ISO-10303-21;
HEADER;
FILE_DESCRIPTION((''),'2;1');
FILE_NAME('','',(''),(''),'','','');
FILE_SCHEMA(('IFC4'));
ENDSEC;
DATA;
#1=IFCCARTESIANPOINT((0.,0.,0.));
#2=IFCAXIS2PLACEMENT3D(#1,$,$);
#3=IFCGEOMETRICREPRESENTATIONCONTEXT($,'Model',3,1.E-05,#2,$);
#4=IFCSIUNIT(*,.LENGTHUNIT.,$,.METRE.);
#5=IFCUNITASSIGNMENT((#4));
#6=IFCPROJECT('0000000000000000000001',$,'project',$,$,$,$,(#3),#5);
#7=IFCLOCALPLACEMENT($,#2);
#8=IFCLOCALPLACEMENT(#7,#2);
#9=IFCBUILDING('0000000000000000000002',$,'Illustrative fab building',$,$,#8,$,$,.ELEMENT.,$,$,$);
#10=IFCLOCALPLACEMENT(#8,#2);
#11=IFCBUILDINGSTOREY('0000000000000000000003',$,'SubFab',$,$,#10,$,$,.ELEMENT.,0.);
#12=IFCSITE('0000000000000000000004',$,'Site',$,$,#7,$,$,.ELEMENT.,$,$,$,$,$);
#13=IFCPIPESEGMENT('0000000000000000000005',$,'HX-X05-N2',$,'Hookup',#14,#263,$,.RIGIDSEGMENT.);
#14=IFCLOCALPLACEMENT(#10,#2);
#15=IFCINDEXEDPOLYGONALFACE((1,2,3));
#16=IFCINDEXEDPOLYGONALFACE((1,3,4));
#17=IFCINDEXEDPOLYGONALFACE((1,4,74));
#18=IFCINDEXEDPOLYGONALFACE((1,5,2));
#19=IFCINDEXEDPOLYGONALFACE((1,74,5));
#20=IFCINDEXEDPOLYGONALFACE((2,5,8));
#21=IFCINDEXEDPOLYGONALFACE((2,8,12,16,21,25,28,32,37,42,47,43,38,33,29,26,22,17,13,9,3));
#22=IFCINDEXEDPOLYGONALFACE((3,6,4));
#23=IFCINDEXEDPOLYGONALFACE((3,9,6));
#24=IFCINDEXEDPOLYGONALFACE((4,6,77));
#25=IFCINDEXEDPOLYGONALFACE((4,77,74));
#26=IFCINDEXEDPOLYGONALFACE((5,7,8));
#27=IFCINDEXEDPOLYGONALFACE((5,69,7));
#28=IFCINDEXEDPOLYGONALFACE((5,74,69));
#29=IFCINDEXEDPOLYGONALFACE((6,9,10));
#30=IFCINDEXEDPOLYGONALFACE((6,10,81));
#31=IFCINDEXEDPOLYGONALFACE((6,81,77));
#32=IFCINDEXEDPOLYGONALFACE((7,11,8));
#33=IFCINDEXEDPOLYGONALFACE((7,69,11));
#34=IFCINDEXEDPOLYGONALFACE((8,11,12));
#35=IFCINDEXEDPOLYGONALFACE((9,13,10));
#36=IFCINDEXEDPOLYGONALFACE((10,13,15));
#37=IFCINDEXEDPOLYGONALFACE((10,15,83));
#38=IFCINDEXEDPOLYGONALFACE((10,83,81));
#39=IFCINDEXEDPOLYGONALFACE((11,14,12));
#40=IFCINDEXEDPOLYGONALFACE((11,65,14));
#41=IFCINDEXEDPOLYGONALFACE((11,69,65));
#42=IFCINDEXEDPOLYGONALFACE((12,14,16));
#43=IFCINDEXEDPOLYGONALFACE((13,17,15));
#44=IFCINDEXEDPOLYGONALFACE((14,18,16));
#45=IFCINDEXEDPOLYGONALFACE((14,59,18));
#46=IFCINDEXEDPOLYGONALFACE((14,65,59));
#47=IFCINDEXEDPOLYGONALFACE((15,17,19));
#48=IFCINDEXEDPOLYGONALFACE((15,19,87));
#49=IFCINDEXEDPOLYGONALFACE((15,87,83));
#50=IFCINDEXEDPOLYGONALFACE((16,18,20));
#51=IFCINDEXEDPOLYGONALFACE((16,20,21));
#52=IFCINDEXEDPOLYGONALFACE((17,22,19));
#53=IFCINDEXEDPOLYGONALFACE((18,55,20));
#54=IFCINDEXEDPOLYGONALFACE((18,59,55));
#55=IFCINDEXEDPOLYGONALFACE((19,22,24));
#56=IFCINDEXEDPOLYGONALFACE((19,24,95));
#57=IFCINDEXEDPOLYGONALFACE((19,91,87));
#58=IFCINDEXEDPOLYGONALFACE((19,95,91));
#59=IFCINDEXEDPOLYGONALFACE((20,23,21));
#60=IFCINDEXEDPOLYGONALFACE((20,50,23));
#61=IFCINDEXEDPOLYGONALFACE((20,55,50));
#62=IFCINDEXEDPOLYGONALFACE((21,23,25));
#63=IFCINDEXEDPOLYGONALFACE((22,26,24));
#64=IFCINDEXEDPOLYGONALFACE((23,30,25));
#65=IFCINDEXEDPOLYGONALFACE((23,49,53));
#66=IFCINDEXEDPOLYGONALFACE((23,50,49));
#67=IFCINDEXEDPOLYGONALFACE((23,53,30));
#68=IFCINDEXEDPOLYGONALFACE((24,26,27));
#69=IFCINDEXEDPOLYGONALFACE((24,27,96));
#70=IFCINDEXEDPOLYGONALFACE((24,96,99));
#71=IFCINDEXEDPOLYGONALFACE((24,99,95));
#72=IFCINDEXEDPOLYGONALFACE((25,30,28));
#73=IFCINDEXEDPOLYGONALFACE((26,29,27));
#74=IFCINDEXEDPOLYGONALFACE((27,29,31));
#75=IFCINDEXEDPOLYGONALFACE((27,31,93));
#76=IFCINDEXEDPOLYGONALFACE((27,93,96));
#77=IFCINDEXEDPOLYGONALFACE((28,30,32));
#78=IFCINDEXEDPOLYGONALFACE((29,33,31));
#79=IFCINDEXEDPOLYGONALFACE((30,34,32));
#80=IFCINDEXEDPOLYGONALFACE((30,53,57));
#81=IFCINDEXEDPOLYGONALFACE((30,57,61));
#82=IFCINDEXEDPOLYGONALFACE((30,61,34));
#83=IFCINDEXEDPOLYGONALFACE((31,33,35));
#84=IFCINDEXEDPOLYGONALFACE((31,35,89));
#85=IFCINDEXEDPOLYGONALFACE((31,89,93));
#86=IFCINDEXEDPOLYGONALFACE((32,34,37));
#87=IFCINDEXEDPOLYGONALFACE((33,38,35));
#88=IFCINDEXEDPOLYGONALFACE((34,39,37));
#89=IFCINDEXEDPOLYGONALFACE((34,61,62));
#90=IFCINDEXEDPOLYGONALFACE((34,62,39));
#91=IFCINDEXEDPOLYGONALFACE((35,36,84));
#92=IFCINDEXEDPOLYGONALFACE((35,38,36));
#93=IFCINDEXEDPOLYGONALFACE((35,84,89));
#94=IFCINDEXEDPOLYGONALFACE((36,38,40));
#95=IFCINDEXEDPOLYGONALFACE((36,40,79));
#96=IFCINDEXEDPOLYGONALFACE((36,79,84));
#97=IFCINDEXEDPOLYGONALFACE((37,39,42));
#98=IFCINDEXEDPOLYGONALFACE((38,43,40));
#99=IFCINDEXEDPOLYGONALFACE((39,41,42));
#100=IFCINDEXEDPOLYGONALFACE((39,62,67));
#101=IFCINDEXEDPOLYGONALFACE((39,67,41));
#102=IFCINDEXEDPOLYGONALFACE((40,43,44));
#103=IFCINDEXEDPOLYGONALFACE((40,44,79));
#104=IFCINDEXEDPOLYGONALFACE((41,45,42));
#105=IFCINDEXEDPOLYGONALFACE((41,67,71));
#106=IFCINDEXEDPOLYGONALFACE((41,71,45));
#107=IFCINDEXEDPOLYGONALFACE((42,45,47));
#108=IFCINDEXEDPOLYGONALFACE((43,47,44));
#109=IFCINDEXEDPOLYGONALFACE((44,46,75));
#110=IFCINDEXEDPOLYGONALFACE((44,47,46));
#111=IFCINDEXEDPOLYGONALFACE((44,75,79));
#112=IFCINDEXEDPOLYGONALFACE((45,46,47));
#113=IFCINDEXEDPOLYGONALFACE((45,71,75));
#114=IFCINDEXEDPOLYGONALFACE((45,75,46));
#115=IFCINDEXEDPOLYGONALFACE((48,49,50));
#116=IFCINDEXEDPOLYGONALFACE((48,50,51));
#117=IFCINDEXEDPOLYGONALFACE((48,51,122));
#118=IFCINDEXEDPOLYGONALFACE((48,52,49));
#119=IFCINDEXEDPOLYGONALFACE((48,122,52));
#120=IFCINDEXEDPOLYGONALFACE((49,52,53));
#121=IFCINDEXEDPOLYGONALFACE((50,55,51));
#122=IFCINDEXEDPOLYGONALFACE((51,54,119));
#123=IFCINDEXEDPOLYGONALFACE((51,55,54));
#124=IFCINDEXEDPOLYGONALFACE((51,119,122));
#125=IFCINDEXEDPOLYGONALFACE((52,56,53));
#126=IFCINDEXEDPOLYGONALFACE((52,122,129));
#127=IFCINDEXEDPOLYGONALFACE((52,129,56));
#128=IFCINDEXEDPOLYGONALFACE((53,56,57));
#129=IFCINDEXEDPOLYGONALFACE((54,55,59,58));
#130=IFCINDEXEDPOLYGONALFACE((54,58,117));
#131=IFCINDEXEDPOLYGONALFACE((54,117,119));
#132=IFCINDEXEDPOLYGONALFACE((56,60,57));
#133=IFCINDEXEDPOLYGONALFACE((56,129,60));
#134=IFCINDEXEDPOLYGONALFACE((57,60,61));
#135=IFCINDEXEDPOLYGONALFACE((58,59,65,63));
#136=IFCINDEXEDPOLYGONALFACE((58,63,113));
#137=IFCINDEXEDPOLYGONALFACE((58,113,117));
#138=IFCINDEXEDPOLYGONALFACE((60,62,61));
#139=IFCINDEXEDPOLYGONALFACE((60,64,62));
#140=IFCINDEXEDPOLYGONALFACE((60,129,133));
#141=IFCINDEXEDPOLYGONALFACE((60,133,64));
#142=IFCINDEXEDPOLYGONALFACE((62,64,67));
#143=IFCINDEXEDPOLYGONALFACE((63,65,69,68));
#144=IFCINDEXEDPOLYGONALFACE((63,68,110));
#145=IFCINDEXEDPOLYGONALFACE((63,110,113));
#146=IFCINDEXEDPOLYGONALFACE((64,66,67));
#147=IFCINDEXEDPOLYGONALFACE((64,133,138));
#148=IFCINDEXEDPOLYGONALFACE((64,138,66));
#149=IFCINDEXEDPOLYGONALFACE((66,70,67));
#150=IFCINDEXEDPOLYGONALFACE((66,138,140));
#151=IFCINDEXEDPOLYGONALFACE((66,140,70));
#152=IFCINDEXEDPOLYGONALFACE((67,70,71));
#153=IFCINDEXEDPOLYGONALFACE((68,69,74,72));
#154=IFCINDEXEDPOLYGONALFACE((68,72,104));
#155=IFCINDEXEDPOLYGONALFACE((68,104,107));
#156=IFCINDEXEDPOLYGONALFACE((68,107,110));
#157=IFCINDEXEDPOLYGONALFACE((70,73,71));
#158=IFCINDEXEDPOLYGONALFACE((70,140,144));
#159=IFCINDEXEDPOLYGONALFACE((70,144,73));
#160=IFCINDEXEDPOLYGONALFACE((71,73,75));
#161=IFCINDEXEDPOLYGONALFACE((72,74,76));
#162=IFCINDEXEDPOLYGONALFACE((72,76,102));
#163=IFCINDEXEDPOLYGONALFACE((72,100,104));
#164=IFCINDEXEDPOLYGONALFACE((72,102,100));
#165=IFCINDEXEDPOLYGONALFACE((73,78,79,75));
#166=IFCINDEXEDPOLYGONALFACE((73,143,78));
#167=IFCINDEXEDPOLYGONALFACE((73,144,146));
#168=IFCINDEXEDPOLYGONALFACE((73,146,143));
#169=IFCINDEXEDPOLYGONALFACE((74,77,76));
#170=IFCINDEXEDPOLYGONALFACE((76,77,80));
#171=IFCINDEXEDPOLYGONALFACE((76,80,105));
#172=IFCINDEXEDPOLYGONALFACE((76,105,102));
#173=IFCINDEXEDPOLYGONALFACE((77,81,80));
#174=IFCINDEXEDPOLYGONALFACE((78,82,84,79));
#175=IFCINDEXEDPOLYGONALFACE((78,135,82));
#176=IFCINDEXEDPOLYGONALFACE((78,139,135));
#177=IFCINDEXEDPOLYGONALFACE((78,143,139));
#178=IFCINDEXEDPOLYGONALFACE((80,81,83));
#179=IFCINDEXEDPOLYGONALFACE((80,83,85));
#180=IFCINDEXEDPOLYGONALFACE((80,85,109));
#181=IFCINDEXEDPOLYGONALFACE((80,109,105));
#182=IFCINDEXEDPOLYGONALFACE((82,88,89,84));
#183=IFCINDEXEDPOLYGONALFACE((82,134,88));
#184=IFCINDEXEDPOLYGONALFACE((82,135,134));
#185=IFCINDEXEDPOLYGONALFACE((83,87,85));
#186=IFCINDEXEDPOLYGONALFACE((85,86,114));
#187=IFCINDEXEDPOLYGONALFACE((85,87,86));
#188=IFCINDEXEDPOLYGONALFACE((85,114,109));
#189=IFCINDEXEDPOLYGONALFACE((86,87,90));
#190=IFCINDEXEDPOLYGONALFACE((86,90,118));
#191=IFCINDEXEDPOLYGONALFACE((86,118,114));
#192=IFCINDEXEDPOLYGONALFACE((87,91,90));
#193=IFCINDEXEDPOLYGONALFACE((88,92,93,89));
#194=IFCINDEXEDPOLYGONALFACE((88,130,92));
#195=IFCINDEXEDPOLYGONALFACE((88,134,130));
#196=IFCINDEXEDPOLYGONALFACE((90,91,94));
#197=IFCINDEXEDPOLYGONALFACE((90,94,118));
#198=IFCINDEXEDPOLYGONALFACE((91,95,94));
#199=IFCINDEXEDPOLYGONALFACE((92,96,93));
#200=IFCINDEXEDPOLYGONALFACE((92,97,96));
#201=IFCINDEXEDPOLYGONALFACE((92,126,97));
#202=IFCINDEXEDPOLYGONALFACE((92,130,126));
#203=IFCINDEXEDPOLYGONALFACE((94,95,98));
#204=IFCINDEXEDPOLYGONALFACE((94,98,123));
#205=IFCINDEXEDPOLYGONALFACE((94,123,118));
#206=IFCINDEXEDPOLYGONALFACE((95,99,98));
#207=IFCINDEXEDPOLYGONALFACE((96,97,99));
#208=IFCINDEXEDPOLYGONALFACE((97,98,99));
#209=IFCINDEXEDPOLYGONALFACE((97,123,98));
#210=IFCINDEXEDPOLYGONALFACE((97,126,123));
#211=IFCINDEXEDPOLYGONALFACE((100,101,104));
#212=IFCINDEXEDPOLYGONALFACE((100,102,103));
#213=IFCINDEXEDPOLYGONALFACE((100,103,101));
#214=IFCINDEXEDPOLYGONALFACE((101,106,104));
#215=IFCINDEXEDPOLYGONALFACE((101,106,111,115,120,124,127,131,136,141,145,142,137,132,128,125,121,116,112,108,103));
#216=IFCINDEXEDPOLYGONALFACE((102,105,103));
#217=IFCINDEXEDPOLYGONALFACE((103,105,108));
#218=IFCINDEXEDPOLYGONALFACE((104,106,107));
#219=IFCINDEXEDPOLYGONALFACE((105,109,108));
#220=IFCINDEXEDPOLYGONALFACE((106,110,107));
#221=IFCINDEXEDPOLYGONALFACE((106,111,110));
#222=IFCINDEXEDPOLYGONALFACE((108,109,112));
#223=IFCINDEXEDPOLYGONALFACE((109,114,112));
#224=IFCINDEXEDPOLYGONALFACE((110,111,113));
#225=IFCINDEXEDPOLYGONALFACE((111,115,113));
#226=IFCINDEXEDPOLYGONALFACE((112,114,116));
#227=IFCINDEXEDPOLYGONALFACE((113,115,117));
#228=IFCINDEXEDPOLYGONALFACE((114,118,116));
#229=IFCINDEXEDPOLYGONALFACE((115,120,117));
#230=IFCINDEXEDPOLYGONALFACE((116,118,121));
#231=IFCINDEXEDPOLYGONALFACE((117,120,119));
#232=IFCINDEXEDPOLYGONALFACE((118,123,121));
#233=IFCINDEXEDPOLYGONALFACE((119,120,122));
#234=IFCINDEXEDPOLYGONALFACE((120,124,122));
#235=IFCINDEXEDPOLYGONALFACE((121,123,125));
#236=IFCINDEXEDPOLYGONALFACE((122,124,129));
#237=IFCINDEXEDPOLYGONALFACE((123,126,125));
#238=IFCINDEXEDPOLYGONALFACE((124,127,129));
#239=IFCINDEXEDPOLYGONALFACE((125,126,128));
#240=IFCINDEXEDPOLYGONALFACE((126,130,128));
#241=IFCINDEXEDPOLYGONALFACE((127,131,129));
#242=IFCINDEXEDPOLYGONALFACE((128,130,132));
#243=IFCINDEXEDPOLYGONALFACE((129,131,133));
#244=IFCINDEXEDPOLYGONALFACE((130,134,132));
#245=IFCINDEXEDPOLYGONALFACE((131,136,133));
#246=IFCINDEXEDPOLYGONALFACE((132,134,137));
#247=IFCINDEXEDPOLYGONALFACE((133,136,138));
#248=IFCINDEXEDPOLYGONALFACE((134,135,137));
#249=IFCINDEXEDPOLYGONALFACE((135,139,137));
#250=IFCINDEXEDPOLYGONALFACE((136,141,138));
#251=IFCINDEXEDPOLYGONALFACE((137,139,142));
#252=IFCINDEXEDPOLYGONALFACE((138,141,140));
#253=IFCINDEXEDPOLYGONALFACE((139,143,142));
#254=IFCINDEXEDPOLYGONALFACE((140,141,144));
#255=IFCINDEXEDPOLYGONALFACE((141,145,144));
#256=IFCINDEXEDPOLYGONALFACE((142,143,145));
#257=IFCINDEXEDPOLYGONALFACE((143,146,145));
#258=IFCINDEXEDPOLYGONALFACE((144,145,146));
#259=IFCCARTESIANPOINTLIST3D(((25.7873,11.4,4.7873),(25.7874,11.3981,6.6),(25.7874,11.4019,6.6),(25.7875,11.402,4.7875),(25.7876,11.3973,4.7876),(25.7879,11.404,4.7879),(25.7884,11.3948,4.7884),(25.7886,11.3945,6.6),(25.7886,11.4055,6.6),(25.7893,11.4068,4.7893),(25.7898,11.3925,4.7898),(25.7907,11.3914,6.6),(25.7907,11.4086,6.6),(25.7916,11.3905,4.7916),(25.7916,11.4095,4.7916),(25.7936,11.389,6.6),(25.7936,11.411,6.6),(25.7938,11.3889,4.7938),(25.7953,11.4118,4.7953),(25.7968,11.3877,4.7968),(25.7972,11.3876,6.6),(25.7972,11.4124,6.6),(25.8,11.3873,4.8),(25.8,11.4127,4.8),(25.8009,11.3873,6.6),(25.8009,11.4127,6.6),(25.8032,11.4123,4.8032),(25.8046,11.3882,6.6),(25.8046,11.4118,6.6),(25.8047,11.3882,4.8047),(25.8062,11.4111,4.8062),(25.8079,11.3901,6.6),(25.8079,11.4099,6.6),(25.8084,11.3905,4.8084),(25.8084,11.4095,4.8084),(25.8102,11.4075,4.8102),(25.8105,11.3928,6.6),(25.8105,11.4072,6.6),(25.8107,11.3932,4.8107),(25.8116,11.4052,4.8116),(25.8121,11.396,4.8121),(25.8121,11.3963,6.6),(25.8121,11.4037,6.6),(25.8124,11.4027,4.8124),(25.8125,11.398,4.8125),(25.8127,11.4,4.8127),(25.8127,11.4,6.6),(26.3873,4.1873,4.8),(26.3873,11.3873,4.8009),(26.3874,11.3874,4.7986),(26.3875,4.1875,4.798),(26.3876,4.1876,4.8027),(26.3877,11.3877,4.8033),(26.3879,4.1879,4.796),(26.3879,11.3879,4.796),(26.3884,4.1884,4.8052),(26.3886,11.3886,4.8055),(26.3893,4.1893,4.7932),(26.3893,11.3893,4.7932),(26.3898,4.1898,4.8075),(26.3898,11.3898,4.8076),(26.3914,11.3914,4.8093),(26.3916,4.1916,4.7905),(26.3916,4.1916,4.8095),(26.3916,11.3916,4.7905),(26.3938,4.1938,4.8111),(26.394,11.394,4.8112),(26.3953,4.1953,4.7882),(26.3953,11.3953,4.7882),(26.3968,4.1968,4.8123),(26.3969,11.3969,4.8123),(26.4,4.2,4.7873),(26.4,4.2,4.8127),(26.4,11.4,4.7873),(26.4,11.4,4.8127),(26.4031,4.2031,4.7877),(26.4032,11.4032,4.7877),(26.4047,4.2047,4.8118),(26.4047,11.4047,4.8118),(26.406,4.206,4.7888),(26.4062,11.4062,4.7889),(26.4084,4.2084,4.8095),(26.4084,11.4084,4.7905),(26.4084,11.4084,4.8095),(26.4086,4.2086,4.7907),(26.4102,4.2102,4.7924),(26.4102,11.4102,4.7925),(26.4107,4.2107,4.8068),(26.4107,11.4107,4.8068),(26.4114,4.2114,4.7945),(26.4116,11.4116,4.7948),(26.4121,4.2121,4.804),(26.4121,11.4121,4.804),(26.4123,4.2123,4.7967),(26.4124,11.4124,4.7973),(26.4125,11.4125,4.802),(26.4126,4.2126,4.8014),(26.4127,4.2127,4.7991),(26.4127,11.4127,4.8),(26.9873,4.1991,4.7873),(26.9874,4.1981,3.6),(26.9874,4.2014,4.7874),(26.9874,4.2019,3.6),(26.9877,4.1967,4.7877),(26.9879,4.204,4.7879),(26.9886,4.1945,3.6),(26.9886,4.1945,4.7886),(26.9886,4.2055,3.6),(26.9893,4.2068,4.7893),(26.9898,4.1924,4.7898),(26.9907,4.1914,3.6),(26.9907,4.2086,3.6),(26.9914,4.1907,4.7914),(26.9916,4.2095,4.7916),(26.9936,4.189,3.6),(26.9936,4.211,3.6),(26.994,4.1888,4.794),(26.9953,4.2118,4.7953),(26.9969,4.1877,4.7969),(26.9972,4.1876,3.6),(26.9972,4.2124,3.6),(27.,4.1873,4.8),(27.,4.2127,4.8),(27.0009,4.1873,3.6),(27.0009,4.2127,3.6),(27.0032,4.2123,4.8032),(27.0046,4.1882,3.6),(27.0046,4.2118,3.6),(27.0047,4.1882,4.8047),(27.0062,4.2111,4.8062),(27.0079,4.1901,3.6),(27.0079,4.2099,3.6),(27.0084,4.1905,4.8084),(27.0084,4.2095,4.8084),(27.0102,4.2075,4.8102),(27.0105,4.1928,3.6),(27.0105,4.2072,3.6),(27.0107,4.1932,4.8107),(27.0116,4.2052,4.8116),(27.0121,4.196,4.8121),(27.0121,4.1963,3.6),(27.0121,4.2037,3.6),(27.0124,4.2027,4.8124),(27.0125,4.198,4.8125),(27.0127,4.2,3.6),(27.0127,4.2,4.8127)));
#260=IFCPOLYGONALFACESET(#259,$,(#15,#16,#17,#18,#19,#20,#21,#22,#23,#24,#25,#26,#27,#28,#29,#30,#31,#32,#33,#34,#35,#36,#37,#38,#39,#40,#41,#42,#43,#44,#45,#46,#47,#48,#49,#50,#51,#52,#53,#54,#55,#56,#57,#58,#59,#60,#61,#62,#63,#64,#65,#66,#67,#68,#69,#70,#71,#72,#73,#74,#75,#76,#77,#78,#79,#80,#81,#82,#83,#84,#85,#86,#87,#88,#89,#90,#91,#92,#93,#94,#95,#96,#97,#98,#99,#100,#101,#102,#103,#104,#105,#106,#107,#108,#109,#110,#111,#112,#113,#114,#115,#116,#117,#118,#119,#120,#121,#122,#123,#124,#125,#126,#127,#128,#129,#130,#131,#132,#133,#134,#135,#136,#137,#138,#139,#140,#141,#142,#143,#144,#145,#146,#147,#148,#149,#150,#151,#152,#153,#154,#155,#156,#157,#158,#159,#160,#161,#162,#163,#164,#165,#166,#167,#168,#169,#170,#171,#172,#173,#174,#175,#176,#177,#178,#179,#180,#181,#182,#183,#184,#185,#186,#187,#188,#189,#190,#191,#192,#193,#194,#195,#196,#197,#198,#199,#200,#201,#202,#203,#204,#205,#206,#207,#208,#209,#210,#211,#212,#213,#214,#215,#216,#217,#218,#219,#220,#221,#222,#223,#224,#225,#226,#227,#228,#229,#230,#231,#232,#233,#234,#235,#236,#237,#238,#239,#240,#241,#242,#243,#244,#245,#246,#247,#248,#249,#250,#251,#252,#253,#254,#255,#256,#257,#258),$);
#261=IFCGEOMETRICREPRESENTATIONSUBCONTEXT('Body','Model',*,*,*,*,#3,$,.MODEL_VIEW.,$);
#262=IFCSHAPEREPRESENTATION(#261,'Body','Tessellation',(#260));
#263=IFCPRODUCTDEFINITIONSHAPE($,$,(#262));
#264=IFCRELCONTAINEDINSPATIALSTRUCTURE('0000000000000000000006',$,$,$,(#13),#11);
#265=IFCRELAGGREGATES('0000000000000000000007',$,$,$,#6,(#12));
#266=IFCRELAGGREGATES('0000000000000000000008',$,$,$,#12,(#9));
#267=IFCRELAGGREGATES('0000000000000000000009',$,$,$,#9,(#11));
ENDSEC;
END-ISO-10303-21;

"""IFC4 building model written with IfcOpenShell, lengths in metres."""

from ifc_helpers import new_model, entity, si_unit, origin, place, context, subcontext, project, spatial, element, save


model = new_model("IFC4")

# Units and contexts
model_context = context("Model", 3, precision=1e-05, world=origin())
body_context = subcontext(model_context, "Body", "Model", "MODEL_VIEW")
ifc_project = project(units=[si_unit("LENGTHUNIT", "METRE")], contexts=[model_context])

# Site, building, storey
site_placement = place(None, origin())
site = spatial("IfcSite", under=ifc_project, at=site_placement, Name="Site", CompositionType="ELEMENT")
building_placement = place(site_placement, origin())
building = spatial("IfcBuilding", under=site, at=building_placement, Name="Illustrative fab building", CompositionType="ELEMENT")
storey_placement = place(building_placement, origin())
storey = spatial("IfcBuildingStorey", under=building, at=storey_placement, Name="SubFab", CompositionType="ELEMENT", Elevation=0.0)

# Pipe segment
pipe_segment_1_placement = place(storey_placement, origin())
element("IfcPipeSegment", 1, at=pipe_segment_1_placement, inside=storey, Name="HX-X05-N2", ObjectType="Hookup", PredefinedType="RIGIDSEGMENT", context=body_context, shape_type="AdvancedSweptSolid", body=[
    entity("IfcSweptDiskSolid", entity("IfcPolyline", [entity("IfcCartesianPoint", [27.0, 4.2, 3.6]), entity("IfcCartesianPoint", [27.0, 4.2, 4.8]), entity("IfcCartesianPoint", [26.4, 4.2, 4.8]), entity("IfcCartesianPoint", [26.4, 11.4, 4.8]), entity("IfcCartesianPoint", [25.8, 11.4, 4.8]), entity("IfcCartesianPoint", [25.8, 11.4, 6.6])]), 0.0127),
])

save(model, "model.ifc")
